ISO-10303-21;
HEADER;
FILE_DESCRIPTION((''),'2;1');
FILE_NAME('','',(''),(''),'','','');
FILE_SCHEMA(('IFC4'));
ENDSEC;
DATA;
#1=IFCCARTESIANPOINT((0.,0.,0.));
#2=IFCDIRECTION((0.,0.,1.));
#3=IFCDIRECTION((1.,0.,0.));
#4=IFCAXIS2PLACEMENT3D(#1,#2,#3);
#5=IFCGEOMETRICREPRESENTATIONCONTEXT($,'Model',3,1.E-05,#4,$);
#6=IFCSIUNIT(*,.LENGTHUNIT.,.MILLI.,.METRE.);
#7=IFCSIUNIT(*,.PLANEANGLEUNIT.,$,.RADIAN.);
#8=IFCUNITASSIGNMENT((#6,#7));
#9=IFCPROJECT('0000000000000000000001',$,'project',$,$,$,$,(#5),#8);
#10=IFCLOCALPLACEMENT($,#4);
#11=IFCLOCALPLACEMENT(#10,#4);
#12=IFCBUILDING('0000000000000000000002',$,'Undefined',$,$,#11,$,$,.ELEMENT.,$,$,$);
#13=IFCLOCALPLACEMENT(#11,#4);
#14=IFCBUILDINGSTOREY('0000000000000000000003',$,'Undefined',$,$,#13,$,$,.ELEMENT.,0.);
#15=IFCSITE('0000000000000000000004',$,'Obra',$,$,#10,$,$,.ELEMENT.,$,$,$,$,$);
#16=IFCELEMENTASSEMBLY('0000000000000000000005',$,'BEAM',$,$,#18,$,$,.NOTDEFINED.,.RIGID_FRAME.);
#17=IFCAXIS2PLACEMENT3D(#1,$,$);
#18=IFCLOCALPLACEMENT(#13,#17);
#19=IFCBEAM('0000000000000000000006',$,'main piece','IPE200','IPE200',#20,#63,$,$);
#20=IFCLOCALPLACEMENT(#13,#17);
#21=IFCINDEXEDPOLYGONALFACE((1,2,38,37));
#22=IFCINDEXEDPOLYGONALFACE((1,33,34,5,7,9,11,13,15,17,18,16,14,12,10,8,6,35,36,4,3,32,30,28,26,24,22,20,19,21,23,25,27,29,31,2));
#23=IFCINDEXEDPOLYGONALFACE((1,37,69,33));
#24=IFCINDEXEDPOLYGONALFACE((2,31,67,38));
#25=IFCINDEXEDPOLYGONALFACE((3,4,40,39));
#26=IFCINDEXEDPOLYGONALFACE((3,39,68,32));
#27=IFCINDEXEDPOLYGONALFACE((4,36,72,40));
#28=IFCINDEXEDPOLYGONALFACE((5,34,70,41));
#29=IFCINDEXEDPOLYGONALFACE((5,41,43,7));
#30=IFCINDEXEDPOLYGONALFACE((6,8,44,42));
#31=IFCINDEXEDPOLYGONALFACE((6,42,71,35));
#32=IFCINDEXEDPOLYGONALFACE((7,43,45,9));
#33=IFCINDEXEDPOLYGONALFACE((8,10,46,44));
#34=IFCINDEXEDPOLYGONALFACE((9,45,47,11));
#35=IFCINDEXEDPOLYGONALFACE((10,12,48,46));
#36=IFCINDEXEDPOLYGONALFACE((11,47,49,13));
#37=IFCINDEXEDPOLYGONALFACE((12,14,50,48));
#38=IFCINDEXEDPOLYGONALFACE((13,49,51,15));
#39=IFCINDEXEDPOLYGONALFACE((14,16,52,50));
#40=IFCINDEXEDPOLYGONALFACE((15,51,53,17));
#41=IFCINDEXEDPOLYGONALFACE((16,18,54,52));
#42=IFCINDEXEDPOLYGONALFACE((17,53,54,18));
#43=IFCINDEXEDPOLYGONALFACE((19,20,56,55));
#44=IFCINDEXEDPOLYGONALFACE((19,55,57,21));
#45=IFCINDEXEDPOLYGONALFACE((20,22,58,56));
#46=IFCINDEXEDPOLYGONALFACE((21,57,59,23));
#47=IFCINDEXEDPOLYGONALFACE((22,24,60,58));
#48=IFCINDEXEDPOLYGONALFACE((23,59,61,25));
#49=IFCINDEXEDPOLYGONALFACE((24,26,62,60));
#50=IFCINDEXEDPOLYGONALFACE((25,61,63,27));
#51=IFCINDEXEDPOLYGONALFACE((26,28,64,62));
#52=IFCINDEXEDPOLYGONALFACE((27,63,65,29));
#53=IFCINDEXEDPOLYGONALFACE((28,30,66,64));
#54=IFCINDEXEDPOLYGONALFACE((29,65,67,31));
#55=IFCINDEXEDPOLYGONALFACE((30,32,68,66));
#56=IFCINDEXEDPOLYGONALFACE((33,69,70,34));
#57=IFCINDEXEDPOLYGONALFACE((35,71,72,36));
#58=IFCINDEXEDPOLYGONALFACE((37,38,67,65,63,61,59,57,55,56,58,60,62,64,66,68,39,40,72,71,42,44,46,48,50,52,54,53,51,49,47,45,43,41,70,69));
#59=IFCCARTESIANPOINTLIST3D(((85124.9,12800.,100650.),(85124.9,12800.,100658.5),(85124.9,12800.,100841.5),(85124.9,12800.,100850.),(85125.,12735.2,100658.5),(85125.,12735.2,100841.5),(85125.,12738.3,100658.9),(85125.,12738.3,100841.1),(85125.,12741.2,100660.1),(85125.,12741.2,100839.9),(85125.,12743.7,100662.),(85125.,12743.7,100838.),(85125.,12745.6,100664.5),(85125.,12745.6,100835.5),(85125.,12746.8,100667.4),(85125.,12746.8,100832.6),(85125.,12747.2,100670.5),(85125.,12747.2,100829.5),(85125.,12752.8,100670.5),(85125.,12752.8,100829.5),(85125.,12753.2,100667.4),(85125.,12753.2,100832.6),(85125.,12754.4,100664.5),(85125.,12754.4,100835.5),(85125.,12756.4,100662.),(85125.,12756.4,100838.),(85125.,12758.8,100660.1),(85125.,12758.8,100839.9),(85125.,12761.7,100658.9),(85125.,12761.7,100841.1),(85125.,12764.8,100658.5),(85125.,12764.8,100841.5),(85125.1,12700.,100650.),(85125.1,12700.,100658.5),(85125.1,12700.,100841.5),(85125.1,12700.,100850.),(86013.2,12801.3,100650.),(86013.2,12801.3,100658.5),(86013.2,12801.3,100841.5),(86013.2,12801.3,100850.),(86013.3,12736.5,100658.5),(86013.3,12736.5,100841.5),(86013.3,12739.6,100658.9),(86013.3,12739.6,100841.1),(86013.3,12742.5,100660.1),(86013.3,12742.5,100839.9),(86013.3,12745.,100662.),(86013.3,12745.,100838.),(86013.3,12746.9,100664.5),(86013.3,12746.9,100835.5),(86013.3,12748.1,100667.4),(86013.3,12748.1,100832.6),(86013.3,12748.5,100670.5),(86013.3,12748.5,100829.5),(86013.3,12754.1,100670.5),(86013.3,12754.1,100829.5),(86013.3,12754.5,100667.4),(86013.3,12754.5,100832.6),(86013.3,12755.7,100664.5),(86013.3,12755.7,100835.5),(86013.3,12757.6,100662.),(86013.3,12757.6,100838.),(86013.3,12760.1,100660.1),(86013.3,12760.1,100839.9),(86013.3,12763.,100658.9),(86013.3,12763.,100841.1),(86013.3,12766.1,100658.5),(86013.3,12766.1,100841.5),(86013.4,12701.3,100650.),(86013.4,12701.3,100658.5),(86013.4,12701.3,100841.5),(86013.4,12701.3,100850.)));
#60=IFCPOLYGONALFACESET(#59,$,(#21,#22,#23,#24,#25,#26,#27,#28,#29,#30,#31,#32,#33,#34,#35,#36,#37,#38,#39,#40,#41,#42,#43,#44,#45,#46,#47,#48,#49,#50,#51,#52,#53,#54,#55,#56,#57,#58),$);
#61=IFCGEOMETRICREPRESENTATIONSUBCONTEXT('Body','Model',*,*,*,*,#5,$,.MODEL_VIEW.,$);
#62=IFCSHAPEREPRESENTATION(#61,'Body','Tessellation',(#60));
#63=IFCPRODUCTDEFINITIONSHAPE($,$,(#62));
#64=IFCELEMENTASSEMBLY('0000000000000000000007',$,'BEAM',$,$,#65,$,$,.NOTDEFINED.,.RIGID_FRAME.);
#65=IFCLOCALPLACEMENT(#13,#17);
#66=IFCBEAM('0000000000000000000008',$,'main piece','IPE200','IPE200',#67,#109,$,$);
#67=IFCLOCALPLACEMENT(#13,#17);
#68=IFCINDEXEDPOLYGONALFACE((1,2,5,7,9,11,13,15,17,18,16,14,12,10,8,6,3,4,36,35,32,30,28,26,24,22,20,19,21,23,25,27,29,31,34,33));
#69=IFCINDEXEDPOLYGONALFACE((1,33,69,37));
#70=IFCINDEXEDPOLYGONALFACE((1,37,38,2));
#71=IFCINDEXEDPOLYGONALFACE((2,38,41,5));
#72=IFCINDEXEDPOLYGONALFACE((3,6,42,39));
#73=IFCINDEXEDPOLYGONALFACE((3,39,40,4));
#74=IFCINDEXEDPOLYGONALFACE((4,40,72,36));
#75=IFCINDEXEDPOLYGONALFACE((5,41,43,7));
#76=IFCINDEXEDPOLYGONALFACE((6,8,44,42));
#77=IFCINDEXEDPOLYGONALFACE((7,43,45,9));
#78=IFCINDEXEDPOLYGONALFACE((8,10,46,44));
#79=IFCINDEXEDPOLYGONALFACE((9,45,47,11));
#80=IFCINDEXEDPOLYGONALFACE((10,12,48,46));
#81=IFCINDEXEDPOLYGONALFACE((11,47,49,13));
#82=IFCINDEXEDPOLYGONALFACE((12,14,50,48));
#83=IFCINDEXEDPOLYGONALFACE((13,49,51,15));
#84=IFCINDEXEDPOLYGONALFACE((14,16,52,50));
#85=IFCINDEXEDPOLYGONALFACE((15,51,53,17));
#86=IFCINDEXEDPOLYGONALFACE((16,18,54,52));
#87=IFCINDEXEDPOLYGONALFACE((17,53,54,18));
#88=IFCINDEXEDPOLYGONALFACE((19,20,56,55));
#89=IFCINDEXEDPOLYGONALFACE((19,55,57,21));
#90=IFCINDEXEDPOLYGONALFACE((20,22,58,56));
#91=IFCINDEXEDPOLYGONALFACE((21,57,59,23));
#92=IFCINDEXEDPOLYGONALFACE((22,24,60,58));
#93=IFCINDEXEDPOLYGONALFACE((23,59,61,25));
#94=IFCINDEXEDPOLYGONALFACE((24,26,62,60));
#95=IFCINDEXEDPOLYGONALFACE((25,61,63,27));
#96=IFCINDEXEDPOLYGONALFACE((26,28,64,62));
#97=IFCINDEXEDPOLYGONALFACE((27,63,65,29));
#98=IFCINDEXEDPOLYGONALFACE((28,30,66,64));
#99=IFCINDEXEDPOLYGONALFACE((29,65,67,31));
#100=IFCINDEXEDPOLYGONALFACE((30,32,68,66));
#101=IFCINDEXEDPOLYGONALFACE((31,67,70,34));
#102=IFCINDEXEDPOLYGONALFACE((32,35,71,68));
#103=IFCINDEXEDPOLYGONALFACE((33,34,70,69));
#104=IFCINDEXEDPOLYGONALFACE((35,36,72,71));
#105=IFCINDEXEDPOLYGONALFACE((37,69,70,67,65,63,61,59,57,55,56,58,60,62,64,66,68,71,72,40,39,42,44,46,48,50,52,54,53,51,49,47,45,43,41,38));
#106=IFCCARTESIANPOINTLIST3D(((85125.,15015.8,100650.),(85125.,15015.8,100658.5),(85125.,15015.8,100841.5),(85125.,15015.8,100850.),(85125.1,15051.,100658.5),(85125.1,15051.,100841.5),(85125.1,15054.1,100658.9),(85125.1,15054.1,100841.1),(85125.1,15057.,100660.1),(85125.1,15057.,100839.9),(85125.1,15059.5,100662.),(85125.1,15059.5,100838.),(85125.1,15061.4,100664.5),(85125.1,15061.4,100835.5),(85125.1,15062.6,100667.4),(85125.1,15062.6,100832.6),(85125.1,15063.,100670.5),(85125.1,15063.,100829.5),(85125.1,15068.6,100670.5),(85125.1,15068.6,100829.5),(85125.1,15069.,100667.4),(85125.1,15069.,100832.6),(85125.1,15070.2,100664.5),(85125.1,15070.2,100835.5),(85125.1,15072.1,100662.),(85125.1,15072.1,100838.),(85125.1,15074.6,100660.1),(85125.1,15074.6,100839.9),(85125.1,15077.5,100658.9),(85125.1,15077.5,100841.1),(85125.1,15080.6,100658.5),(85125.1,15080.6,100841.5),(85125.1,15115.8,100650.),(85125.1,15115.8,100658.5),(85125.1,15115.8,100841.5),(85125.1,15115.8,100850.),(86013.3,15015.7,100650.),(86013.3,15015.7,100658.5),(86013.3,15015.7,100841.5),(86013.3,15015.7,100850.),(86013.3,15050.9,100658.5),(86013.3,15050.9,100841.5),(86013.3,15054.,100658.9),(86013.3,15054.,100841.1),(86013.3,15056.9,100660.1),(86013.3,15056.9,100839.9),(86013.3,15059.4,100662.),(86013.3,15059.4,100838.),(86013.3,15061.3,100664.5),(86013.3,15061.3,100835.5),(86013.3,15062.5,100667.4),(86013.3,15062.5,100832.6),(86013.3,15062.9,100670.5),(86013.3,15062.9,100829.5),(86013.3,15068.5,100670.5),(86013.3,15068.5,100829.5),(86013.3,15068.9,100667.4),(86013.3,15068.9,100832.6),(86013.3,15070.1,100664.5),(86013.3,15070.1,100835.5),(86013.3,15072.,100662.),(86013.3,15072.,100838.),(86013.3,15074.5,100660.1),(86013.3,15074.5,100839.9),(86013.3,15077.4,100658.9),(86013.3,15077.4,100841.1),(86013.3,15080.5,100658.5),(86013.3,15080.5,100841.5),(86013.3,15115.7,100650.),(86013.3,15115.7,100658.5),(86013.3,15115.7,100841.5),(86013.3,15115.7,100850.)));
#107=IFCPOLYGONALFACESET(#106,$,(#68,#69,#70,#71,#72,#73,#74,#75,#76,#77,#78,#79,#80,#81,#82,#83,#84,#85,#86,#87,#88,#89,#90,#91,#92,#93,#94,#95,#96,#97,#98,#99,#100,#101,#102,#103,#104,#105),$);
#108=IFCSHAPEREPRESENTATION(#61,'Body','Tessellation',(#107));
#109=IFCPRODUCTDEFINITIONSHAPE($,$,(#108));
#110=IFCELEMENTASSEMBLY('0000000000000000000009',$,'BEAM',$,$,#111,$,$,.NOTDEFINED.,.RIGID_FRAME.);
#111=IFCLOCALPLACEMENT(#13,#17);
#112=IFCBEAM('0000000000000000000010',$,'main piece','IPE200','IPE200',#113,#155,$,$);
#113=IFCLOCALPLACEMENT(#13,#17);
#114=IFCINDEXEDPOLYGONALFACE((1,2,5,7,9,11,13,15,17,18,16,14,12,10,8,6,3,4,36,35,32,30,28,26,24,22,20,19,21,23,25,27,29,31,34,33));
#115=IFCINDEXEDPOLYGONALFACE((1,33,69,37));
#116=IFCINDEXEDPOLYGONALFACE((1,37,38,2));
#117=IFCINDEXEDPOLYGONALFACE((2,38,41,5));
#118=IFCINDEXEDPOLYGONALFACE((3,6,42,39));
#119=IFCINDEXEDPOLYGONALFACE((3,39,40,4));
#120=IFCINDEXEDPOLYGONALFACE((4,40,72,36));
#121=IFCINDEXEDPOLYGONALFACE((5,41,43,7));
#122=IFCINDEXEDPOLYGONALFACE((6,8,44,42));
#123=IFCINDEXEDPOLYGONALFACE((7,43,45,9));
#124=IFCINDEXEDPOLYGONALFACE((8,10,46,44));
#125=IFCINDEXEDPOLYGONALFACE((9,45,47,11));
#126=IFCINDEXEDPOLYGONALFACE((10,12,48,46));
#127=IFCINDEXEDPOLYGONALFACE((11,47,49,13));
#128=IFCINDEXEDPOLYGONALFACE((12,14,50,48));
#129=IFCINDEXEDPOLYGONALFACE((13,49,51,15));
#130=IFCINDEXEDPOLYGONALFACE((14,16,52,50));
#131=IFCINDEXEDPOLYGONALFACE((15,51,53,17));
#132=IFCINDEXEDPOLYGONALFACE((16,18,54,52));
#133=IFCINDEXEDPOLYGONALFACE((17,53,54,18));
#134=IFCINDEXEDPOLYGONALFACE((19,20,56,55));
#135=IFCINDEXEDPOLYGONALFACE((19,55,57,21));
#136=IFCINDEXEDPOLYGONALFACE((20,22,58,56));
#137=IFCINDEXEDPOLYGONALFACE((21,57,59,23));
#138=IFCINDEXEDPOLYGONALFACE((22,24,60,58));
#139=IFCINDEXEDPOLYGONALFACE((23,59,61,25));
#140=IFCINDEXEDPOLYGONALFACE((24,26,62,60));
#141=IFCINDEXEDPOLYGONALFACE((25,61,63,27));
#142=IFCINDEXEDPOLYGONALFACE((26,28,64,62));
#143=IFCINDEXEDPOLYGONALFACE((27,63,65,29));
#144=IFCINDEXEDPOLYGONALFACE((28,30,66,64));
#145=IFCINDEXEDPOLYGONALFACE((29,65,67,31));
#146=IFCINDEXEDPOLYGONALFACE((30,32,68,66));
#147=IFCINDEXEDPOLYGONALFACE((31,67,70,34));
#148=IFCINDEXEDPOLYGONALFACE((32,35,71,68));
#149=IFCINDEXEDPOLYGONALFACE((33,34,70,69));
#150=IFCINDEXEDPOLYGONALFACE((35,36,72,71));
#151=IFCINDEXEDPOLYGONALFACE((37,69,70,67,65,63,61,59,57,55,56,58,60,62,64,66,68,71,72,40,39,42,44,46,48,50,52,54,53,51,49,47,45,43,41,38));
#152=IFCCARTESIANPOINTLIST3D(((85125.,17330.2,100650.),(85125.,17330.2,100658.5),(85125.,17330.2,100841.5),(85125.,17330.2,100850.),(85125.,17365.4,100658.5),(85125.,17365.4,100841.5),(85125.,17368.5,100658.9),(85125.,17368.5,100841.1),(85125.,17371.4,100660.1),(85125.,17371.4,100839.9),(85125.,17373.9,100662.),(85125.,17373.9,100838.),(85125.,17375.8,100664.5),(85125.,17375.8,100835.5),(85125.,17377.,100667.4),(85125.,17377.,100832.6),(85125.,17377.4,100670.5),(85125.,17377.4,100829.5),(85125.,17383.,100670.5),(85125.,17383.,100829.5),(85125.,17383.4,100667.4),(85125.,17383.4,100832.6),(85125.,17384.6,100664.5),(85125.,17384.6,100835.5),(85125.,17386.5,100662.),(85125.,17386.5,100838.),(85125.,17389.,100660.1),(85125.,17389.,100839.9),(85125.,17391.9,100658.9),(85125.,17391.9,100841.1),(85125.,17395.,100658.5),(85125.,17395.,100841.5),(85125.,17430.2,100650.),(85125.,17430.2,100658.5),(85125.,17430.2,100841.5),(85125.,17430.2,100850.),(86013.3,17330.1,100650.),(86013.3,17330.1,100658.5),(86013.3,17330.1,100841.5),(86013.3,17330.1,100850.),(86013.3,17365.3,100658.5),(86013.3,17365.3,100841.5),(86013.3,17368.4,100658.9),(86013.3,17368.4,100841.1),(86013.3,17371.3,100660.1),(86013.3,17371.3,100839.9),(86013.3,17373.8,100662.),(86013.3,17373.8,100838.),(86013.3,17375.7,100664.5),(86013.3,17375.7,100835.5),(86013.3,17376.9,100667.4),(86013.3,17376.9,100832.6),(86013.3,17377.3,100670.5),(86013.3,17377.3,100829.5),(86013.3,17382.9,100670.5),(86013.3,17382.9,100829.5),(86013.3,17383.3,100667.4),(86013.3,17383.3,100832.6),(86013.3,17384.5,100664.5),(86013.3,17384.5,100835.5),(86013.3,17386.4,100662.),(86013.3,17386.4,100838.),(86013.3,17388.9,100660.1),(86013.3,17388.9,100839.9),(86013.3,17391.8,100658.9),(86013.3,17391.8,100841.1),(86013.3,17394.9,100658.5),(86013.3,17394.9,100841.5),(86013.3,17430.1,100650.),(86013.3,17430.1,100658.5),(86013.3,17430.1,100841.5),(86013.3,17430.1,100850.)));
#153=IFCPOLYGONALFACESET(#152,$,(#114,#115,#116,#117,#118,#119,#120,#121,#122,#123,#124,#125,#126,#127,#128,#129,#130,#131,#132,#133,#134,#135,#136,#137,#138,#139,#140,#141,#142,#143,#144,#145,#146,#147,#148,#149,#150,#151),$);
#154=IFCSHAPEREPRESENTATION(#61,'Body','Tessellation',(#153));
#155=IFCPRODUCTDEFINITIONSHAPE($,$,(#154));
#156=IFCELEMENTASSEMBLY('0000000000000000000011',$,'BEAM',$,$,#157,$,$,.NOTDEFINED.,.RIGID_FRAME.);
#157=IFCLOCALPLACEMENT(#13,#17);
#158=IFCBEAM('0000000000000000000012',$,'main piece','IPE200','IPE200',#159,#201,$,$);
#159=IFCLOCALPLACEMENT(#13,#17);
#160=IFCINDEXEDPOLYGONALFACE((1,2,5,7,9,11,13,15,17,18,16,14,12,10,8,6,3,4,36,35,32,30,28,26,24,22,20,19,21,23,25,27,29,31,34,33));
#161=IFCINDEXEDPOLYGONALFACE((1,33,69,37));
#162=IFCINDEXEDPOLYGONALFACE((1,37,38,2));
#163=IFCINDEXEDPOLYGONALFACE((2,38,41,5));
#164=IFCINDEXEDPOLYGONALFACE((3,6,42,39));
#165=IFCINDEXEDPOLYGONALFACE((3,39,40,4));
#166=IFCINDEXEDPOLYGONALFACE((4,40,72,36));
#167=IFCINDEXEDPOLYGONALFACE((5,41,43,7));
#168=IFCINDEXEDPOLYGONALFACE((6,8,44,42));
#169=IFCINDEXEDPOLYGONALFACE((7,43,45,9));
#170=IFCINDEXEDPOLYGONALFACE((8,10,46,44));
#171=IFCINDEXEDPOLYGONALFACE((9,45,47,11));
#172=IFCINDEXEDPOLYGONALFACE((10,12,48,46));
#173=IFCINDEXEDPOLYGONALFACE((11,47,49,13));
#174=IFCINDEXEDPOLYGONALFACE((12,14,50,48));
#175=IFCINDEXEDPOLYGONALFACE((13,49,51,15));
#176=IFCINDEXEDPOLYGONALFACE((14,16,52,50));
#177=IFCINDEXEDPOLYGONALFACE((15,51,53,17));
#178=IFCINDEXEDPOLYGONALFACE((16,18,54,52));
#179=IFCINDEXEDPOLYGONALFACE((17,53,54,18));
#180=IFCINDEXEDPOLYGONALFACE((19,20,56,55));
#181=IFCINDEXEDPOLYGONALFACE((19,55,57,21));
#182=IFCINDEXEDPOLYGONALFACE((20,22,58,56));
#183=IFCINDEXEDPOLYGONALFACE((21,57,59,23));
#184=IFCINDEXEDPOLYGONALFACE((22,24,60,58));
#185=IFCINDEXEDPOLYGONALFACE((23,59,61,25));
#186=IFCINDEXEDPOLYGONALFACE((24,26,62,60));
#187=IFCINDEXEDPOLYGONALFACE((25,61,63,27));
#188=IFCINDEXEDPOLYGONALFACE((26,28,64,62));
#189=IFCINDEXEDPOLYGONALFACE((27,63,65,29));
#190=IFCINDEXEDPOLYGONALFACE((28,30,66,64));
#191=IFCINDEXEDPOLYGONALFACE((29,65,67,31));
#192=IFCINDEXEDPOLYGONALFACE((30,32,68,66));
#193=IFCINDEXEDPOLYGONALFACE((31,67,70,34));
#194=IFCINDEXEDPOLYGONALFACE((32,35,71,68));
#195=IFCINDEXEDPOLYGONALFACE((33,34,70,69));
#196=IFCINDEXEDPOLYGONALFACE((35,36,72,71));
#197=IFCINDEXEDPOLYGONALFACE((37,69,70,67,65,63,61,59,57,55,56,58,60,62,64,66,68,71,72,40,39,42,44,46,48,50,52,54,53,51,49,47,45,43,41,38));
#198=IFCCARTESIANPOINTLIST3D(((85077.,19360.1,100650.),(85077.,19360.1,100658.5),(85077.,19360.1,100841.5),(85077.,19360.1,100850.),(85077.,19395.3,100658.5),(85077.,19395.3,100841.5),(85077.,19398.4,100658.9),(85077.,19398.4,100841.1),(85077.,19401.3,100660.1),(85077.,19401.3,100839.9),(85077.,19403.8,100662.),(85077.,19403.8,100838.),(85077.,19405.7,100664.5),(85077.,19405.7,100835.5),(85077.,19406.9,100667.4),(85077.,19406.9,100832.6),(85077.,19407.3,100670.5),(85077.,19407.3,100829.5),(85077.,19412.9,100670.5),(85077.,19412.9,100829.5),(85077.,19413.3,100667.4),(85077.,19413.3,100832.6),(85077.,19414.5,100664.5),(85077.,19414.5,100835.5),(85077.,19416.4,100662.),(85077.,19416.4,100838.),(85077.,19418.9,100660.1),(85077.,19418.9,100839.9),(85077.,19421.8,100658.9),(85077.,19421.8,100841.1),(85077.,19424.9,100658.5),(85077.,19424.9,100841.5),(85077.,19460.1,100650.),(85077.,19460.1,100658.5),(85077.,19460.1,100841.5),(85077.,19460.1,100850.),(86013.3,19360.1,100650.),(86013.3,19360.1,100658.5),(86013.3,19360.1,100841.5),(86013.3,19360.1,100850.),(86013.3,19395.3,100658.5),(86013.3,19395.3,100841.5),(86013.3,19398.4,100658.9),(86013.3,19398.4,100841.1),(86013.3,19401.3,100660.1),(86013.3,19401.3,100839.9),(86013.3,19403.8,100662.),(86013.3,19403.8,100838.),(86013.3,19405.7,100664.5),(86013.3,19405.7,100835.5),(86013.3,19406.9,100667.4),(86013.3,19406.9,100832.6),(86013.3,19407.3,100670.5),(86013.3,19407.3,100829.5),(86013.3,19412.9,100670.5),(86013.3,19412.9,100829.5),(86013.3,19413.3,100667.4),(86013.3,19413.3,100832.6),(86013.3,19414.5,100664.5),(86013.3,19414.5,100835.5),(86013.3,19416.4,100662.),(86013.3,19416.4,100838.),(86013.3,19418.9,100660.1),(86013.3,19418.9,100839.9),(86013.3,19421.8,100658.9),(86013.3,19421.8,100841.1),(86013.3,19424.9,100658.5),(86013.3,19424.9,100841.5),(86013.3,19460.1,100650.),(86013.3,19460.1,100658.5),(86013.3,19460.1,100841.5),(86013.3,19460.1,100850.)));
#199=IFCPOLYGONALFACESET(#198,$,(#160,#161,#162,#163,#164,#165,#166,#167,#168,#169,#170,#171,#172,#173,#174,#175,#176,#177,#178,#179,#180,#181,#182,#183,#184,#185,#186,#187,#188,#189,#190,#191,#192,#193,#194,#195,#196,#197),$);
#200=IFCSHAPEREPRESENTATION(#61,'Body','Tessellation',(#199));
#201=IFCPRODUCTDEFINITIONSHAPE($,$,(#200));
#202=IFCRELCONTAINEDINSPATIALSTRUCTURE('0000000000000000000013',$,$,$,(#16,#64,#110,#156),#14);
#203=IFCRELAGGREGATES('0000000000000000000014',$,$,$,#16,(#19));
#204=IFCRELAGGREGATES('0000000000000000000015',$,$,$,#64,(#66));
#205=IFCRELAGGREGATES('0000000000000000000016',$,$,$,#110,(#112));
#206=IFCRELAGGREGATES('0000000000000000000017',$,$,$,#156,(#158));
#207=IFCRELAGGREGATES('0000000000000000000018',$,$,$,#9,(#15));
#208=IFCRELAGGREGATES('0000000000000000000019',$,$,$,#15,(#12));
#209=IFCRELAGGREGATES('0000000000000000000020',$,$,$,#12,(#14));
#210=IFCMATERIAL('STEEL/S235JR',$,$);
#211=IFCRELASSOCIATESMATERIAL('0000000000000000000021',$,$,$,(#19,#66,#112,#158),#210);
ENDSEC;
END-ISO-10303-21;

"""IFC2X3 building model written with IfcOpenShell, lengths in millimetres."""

from ifc_helpers import new_model, si_unit, frame, origin_with_axes, origin_2d_with_axis, place, context, subcontext, project, spatial, i_section, extrude, material, element, aggregate, save


model = new_model("IFC2X3")

# Units and contexts
model_context = context("Model", 3, precision=1e-05, world=origin_with_axes())
body_context = subcontext(model_context, "Body", "Model", "MODEL_VIEW")
ifc_project = project(units=[si_unit("LENGTHUNIT", "METRE", prefix="MILLI"), si_unit("PLANEANGLEUNIT", "RADIAN")], contexts=[model_context])

# Site, building, storey
site_placement = place(None, origin_with_axes())
site = spatial("IfcSite", under=ifc_project, at=site_placement, Name="Obra", CompositionType="ELEMENT")
building_placement = place(site_placement, origin_with_axes())
building = spatial("IfcBuilding", under=site, at=building_placement, Name="Undefined", CompositionType="ELEMENT")
storey_placement = place(building_placement, origin_with_axes())
storey = spatial("IfcBuildingStorey", under=building, at=storey_placement, Name="Undefined", CompositionType="ELEMENT", Elevation=0.0)

# Element assemblies, beams
assembly_1_placement = place(storey_placement, origin_with_axes())
assembly_1 = element("IfcElementAssembly", 1, at=assembly_1_placement, inside=storey, Name="BEAM", AssemblyPlace="NOTDEFINED", PredefinedType="RIGID_FRAME")
ifc_material = material(Name="STEEL/S235JR")
beam_1_placement = place(assembly_1_placement, frame((85125.0, 12750.0, 100750.0), z_axis=(0.0, 0.0, 1.0), x_axis=(0.999999, 0.001449, 0.0)))
beam_1 = element("IfcBeam", 2, at=beam_1_placement, material=ifc_material, Name="main piece", Description="IPE200", ObjectType="IPE200", context=body_context, shape_type="SweptSolid", body=[
    extrude(i_section(OverallWidth=100.0, OverallDepth=200.0, WebThickness=5.6, FlangeThickness=8.5, FilletRadius=12.0, at=origin_2d_with_axis()), frame((888.3, 0.0, 0.0), z_axis=(-1.0, 0.0, 0.0), x_axis=(0.0, -1.0, 0.0)), (0.0, 0.0, 1.0), 888.3),
])
aggregate(assembly_1, [beam_1])
assembly_2_placement = place(storey_placement, origin_with_axes())
assembly_2 = element("IfcElementAssembly", 3, at=assembly_2_placement, inside=storey, Name="BEAM", AssemblyPlace="NOTDEFINED", PredefinedType="RIGID_FRAME")
beam_2_placement = place(assembly_2_placement, frame((85125.0, 15065.8, 100750.0), z_axis=(0.0, 0.0, 1.0), x_axis=(1.0, -0.000043, 0.0)))
beam_2 = element("IfcBeam", 4, at=beam_2_placement, material=ifc_material, Name="main piece", Description="IPE200", ObjectType="IPE200", context=body_context, shape_type="SweptSolid", body=[
    extrude(i_section(OverallWidth=100.0, OverallDepth=200.0, WebThickness=5.6, FlangeThickness=8.5, FilletRadius=12.0, at=origin_2d_with_axis()), frame((888.3, 0.0, 0.0), z_axis=(-1.0, 0.0, 0.0), x_axis=(0.0, -1.0, 0.0)), (0.0, 0.0, 1.0), 888.2),
])
aggregate(assembly_2, [beam_2])
assembly_3_placement = place(storey_placement, origin_with_axes())
assembly_3 = element("IfcElementAssembly", 5, at=assembly_3_placement, inside=storey, Name="BEAM", AssemblyPlace="NOTDEFINED", PredefinedType="RIGID_FRAME")
beam_3_placement = place(assembly_3_placement, frame((85125.0, 17380.2, 100750.0), z_axis=(0.0, 0.0, 1.0), x_axis=(1.0, -0.000084, 0.0)))
beam_3 = element("IfcBeam", 6, at=beam_3_placement, material=ifc_material, Name="main piece", Description="IPE200", ObjectType="IPE200", context=body_context, shape_type="SweptSolid", body=[
    extrude(i_section(OverallWidth=100.0, OverallDepth=200.0, WebThickness=5.6, FlangeThickness=8.5, FilletRadius=12.0, at=origin_2d_with_axis()), frame((888.3, 0.0, 0.0), z_axis=(-1.0, 0.0, 0.0), x_axis=(0.0, -1.0, 0.0)), (0.0, 0.0, 1.0), 888.3),
])
aggregate(assembly_3, [beam_3])
assembly_4_placement = place(storey_placement, origin_with_axes())
assembly_4 = element("IfcElementAssembly", 7, at=assembly_4_placement, inside=storey, Name="BEAM", AssemblyPlace="NOTDEFINED", PredefinedType="RIGID_FRAME")
beam_4_placement = place(assembly_4_placement, frame((85077.0, 19410.1, 100750.0), z_axis=(0.0, 0.0, 1.0), x_axis=(1.0, 0.0, 0.0)))
beam_4 = element("IfcBeam", 8, at=beam_4_placement, material=ifc_material, Name="main piece", Description="IPE200", ObjectType="IPE200", context=body_context, shape_type="SweptSolid", body=[
    extrude(i_section(OverallWidth=100.0, OverallDepth=200.0, WebThickness=5.6, FlangeThickness=8.5, FilletRadius=12.0, at=origin_2d_with_axis()), frame((936.3, 0.0, 0.0), z_axis=(-1.0, 0.0, 0.0), x_axis=(0.0, -1.0, 0.0)), (0.0, 0.0, 1.0), 936.3),
])
aggregate(assembly_4, [beam_4])

save(model, "model.ifc")
